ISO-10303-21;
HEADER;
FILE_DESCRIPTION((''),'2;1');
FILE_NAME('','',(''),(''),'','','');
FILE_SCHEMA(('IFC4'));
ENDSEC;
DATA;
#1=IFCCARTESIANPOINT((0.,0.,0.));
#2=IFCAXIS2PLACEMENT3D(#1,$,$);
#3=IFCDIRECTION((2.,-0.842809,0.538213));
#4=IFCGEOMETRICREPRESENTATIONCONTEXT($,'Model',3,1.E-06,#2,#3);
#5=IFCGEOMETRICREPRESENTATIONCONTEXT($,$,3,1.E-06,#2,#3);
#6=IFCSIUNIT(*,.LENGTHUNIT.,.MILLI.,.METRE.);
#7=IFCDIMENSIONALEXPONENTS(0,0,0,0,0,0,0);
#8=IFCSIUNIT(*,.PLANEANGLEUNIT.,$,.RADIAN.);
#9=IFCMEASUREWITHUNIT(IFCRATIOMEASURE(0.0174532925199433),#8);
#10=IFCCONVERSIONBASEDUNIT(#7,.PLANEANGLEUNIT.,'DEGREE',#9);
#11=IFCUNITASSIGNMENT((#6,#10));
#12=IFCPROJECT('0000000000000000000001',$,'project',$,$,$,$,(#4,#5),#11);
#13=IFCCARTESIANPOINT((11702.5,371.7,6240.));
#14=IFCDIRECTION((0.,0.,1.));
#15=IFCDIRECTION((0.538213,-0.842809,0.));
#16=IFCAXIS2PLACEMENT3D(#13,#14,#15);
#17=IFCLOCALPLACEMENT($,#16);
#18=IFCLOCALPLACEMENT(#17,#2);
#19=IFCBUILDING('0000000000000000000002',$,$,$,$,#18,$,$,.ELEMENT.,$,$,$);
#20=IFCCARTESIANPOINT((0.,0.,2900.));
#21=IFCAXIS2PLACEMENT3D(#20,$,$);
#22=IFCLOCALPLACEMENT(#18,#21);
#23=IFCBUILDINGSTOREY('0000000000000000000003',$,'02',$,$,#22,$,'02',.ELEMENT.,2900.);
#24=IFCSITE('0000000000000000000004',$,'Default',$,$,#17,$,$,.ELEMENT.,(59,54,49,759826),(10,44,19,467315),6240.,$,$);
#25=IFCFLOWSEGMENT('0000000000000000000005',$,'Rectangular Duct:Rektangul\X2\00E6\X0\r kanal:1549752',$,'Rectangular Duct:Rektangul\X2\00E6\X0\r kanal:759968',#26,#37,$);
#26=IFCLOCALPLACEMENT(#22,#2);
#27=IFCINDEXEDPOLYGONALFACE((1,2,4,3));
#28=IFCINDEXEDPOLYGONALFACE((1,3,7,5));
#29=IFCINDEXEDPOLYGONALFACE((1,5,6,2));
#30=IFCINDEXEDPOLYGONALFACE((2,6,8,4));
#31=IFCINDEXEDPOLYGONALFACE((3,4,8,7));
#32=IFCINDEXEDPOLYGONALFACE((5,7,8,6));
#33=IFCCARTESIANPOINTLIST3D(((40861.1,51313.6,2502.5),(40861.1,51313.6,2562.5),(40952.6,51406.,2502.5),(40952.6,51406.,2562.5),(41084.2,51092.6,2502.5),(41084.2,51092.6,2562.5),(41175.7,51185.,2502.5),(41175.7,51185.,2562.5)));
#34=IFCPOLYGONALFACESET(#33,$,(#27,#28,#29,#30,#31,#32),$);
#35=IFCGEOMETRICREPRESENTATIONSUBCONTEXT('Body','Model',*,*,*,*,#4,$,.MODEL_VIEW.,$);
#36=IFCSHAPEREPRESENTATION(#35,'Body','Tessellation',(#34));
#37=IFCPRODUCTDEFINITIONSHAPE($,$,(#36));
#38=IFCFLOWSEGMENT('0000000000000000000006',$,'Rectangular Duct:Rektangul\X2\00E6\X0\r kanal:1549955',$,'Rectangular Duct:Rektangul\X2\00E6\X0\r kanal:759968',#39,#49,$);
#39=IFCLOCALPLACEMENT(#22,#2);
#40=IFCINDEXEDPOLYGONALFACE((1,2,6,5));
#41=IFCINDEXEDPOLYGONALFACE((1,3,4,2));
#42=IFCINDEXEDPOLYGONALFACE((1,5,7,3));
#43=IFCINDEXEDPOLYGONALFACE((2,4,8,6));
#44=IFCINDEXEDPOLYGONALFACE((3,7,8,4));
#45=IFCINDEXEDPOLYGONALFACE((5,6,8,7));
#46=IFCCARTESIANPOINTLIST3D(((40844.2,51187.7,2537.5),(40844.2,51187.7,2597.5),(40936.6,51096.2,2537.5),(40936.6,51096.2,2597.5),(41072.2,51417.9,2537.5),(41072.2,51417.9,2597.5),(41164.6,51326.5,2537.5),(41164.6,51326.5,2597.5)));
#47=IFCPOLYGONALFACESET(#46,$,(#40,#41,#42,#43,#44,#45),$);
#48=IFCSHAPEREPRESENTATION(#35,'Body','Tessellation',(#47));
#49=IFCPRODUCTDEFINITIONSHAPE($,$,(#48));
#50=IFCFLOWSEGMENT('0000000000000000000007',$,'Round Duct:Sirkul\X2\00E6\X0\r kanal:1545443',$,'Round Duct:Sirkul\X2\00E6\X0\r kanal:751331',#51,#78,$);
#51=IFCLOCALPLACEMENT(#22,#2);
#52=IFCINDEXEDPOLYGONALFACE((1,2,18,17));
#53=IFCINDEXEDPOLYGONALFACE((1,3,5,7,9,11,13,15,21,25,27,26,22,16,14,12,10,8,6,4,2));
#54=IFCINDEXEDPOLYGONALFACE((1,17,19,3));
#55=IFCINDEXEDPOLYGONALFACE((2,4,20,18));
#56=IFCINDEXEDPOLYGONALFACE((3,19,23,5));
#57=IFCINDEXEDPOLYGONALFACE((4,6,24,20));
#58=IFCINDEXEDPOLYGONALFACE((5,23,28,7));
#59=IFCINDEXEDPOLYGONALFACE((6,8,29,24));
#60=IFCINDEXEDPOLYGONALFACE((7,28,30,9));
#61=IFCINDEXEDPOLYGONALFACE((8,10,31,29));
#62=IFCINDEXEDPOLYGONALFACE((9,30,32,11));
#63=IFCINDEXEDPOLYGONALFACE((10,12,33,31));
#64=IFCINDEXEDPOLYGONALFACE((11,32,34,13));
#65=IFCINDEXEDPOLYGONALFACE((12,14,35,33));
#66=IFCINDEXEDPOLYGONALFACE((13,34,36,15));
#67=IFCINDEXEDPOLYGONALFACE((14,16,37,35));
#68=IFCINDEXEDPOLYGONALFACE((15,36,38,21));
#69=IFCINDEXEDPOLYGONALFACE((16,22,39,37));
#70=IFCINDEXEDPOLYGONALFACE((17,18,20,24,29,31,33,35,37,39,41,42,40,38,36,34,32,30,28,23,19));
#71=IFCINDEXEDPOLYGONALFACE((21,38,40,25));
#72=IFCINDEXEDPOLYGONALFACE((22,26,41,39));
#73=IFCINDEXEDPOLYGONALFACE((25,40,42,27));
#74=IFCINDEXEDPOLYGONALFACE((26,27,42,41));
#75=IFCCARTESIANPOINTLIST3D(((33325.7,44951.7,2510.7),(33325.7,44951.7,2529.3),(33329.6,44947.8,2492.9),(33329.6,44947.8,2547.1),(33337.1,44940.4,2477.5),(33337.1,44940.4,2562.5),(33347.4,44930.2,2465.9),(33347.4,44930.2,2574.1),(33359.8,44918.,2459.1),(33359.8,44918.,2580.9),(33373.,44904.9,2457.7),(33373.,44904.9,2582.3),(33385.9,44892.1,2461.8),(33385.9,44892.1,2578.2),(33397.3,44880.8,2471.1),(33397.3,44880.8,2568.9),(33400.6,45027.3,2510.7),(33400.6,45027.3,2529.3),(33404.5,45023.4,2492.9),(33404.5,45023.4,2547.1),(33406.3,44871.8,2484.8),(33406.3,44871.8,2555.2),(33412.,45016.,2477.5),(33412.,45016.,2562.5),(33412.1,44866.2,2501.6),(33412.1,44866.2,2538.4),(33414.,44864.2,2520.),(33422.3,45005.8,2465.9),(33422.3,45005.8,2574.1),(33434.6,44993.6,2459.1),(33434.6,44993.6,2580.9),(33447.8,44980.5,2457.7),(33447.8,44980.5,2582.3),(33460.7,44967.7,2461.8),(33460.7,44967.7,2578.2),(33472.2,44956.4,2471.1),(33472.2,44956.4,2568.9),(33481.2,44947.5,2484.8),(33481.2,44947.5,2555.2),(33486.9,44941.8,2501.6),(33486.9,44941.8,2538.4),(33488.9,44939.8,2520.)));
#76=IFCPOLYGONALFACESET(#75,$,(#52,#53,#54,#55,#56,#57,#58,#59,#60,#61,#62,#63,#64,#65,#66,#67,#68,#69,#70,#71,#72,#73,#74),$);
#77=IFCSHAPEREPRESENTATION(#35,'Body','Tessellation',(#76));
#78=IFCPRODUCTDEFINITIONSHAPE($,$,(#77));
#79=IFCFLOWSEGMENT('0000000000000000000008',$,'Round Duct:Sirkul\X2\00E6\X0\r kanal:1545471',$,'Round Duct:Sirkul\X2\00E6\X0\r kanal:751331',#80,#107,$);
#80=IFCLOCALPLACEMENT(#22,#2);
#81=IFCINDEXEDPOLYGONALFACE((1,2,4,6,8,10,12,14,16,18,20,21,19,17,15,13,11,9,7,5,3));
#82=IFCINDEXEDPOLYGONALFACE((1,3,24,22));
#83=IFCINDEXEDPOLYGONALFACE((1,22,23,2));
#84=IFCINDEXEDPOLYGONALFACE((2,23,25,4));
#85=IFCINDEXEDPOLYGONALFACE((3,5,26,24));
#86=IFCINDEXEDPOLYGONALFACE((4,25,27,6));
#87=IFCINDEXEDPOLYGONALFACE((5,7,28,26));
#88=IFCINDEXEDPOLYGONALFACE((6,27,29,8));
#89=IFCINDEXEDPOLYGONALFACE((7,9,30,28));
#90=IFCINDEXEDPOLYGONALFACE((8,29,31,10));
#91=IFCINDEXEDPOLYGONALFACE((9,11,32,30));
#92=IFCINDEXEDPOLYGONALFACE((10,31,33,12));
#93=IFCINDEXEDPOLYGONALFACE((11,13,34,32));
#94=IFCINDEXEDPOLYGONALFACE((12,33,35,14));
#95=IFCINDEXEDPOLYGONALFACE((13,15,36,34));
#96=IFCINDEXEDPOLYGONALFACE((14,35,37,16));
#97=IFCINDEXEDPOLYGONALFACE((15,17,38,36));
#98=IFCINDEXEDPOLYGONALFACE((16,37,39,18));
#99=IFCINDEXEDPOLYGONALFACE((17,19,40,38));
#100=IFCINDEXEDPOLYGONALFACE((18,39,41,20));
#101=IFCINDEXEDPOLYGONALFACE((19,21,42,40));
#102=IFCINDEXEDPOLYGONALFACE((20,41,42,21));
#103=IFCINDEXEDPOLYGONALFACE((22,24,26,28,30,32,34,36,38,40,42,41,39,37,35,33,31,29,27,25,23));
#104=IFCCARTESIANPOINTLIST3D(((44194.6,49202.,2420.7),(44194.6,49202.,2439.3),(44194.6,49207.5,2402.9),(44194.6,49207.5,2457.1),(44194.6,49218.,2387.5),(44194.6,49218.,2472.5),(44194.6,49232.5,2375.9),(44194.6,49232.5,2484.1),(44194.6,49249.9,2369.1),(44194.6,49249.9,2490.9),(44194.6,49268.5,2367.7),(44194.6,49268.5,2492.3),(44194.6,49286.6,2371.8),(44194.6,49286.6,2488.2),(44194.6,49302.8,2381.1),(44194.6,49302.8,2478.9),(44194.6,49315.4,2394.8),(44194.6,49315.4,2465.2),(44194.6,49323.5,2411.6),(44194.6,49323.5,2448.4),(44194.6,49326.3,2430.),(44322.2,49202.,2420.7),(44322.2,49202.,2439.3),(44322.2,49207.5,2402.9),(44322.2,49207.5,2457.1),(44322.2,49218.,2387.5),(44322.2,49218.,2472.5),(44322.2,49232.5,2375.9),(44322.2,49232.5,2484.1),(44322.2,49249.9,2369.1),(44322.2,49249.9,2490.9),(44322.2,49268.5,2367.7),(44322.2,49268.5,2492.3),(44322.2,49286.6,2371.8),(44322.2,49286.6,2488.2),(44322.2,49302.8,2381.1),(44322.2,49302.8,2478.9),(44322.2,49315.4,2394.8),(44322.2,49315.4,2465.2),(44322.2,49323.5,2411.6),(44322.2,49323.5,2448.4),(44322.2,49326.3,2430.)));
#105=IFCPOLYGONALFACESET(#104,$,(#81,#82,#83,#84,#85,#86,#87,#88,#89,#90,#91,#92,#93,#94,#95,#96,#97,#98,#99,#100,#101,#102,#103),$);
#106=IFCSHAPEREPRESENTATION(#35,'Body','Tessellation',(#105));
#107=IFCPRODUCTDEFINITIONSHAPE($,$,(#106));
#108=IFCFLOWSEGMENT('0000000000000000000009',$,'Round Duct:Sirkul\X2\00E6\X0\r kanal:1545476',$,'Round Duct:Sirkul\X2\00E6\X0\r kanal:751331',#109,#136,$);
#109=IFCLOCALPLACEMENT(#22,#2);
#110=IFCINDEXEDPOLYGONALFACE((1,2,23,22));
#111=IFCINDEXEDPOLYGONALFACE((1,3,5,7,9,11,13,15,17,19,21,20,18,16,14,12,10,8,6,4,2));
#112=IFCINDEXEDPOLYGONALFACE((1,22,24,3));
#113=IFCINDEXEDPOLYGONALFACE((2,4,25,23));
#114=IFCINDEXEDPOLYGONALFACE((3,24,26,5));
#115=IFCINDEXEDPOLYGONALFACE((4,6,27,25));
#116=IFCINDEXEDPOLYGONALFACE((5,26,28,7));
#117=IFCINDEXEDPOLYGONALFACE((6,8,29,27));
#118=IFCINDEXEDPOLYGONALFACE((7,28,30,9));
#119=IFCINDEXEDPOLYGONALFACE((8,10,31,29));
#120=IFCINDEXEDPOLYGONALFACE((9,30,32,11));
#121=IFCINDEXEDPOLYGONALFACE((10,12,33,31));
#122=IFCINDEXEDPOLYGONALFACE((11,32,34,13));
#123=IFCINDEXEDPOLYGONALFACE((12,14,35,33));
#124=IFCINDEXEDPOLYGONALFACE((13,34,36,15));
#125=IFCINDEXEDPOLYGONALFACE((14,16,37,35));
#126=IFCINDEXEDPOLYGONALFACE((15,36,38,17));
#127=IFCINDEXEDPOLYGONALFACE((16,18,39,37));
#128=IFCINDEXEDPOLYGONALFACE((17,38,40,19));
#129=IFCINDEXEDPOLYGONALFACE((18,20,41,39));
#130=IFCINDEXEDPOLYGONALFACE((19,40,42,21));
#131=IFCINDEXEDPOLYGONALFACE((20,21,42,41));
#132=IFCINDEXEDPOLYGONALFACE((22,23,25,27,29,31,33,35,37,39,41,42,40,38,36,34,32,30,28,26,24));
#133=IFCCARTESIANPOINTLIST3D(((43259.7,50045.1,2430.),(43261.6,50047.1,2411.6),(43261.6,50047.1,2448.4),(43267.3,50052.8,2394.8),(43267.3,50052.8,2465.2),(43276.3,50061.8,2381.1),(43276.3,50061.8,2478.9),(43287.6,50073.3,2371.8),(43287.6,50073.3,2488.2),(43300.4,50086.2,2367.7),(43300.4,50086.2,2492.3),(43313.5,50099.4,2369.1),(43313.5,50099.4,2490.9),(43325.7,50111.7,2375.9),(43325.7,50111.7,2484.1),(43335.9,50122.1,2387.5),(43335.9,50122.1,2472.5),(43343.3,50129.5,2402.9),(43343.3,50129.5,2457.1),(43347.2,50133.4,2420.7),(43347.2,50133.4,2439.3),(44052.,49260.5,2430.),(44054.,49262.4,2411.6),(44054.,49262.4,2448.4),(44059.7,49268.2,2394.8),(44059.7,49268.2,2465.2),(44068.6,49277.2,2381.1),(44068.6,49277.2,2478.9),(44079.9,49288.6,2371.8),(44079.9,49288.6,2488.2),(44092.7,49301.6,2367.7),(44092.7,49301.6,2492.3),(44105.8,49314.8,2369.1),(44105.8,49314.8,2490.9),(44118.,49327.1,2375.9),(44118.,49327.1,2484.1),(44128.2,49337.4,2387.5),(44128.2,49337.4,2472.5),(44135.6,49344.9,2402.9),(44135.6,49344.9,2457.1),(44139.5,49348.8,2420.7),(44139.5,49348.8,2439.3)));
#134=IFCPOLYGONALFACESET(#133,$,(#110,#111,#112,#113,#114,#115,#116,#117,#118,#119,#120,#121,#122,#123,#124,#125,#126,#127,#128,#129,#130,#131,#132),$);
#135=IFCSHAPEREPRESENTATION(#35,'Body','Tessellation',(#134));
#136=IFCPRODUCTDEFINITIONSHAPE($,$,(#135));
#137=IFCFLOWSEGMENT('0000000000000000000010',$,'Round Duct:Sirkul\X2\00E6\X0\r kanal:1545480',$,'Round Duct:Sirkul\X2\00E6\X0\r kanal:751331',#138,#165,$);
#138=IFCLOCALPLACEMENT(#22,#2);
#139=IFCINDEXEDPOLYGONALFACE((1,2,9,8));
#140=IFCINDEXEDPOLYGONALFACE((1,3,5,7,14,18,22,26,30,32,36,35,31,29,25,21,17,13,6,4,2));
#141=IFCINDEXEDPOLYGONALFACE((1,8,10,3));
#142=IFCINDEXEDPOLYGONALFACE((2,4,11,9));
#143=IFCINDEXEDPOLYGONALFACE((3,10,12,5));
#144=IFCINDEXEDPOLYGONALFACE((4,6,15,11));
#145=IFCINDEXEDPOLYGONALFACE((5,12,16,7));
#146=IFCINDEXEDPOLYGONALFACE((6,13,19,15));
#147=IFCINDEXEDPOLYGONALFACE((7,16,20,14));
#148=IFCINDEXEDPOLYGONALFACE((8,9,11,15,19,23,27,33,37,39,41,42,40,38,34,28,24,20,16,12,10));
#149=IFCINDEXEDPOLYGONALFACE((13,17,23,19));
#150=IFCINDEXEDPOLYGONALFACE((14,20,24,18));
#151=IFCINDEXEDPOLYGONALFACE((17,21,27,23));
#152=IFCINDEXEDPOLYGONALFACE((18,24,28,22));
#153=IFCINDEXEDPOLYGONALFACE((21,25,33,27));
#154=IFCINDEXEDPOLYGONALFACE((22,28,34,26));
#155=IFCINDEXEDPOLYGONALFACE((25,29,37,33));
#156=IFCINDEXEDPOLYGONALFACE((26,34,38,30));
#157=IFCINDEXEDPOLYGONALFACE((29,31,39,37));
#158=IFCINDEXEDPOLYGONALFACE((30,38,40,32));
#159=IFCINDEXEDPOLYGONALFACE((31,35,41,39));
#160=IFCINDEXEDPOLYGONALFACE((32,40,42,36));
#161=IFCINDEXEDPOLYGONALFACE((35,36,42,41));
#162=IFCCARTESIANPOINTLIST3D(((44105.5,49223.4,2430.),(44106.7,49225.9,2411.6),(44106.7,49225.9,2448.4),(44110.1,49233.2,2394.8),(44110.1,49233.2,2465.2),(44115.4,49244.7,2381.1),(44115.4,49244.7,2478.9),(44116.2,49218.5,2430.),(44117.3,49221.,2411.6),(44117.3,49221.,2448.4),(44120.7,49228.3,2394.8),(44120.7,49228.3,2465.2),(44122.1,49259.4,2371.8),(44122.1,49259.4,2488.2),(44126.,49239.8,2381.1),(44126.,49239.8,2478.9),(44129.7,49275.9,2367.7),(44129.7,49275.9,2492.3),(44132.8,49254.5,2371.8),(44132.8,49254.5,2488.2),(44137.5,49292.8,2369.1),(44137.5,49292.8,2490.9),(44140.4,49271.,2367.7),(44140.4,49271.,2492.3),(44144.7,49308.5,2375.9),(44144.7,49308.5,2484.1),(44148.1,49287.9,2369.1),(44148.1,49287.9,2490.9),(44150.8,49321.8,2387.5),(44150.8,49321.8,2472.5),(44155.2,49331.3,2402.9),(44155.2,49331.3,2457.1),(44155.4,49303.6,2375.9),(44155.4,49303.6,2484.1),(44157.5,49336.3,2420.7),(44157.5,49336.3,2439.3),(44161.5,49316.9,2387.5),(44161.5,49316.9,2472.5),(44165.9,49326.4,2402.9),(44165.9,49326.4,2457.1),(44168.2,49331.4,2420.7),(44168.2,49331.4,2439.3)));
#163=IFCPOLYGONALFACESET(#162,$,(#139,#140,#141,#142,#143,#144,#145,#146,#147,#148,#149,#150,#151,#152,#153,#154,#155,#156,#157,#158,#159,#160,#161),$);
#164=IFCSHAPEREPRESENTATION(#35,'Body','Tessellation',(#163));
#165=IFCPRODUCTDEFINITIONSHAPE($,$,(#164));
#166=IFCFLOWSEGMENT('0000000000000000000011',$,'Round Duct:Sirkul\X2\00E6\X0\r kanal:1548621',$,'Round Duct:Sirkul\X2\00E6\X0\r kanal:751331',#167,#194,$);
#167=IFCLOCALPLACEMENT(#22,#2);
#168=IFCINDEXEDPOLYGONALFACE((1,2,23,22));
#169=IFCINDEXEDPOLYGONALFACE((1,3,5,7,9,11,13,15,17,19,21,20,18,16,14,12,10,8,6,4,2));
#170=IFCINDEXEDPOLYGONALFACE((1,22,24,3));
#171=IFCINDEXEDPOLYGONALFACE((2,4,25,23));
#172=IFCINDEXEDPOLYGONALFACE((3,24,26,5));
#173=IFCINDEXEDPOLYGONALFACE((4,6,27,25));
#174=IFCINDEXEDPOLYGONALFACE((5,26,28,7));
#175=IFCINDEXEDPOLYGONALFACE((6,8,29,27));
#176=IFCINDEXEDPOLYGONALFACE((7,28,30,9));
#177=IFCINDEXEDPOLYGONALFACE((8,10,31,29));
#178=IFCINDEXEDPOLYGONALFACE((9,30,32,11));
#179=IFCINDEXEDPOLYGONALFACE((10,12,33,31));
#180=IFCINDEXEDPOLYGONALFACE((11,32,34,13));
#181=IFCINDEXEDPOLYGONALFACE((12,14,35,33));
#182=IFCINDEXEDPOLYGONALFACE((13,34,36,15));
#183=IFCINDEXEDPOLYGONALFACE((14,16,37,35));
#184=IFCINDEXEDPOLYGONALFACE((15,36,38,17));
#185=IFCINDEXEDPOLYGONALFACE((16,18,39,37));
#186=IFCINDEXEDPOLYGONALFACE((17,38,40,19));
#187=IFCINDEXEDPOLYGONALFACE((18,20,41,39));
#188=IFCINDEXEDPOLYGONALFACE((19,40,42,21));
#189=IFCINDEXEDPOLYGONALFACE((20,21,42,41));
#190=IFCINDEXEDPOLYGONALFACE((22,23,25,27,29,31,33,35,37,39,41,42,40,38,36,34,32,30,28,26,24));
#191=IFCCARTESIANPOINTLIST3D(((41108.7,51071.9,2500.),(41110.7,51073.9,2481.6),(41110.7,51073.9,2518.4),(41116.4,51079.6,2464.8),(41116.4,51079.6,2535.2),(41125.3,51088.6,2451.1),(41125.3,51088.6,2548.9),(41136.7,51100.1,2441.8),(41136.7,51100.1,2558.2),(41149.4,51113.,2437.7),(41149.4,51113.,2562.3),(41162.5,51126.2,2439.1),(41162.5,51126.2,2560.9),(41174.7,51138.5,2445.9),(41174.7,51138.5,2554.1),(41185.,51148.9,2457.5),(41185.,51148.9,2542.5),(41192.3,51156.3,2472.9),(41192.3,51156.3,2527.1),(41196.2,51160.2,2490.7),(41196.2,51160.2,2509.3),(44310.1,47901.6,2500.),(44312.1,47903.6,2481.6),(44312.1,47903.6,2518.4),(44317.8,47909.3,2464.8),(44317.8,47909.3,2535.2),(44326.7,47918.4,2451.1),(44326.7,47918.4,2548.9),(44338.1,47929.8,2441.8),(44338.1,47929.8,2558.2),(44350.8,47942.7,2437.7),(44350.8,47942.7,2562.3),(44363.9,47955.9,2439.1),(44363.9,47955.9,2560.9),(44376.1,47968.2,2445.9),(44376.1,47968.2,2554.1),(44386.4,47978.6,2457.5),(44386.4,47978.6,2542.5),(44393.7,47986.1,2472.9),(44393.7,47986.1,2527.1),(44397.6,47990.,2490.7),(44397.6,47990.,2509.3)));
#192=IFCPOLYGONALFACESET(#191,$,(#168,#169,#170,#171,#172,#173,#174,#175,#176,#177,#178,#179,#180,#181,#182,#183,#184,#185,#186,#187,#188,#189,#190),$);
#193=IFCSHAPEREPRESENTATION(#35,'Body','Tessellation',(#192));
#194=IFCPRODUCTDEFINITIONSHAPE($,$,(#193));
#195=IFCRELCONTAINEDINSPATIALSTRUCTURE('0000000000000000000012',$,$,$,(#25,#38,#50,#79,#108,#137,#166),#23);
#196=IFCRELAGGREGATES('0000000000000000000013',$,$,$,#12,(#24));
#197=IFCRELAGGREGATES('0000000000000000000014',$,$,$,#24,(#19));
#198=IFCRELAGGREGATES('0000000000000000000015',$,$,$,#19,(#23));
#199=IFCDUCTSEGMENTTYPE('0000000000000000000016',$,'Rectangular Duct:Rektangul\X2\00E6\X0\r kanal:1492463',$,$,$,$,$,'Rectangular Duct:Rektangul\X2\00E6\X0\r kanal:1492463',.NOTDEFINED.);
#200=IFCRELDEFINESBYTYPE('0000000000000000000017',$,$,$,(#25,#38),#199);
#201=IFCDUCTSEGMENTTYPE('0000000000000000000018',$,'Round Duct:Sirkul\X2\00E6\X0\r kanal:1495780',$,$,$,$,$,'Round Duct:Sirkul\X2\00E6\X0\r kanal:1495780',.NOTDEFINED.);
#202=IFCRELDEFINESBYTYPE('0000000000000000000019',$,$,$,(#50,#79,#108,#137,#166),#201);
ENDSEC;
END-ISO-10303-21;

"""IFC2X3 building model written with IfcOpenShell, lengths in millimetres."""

from ifc_helpers import new_model, entity, si_unit, converted_unit, direction, frame, frame_2d, origin, origin_2d_with_axis, place, context, subcontext, project, spatial, rectangle, circle, extrude, type_object, element, save


model = new_model("IFC2X3")

# Units and contexts
model_context = context("Model", 3, precision=1e-06, world=origin(), true_north=direction((2.0, -0.842809, 0.538213)))
context_of_model = context(None, 3, precision=1e-06, world=origin(), true_north=direction((2.0, -0.842809, 0.538213)))
body_context = subcontext(model_context, "Body", "Model", "MODEL_VIEW")
ifc_project = project(units=[si_unit("LENGTHUNIT", "METRE", prefix="MILLI"), converted_unit("PLANEANGLEUNIT", "DEGREE", entity("IfcRatioMeasure", 0.0174532925199433), si_unit("PLANEANGLEUNIT", "RADIAN"), dimensions=[0, 0, 0, 0, 0, 0, 0])], contexts=[model_context, context_of_model])

# Site, building, storey
site_placement = place(None, frame((11702.5, 371.7, 6240.0), z_axis=(0.0, 0.0, 1.0), x_axis=(0.538213, -0.842809, 0.0)))
site = spatial("IfcSite", under=ifc_project, at=site_placement, Name="Default", CompositionType="ELEMENT", RefLatitude=(59, 54, 49, 759826), RefLongitude=(10, 44, 19, 467315), RefElevation=6240.0)
building_placement = place(site_placement, origin())
building = spatial("IfcBuilding", under=site, at=building_placement, CompositionType="ELEMENT")
storey_placement = place(building_placement, frame((0.0, 0.0, 2900.0)))
storey = spatial("IfcBuildingStorey", under=building, at=storey_placement, Name="02", LongName="02", CompositionType="ELEMENT", Elevation=2900.0)

# Flow segments
duct_segment_type_1 = type_object("IfcDuctSegmentType", Name="Rectangular Duct:Rektangulær kanal:1492463", ElementType="Rectangular Duct:Rektangulær kanal:1492463", PredefinedType="NOTDEFINED")
flow_segment_1_placement = place(storey_placement, origin())
element("IfcFlowSegment", 1, at=flow_segment_1_placement, inside=storey, type_object=duct_segment_type_1, Name="Rectangular Duct:Rektangulær kanal:1549752", ObjectType="Rectangular Duct:Rektangulær kanal:759968", context=body_context, shape_type="SweptSolid", body=[
    extrude(rectangle(XDim=314.0, YDim=130.0, at=frame_2d((0.0, 0.0), x_axis=(1.0, 0.0))), frame((41018.4, 51249.3, 2502.5), z_axis=(0.0, 0.0, 1.0), x_axis=(0.710554, -0.703643, 0.0)), (0.0, 0.0, 1.0), 60.0),
])
flow_segment_2_placement = place(storey_placement, origin())
element("IfcFlowSegment", 2, at=flow_segment_2_placement, inside=storey, type_object=duct_segment_type_1, Name="Rectangular Duct:Rektangulær kanal:1549955", ObjectType="Rectangular Duct:Rektangulær kanal:759968", context=body_context, shape_type="SweptSolid", body=[
    extrude(rectangle(XDim=324.0, YDim=130.0, at=origin_2d_with_axis()), frame((41004.4, 51257.1, 2537.5), z_axis=(0.0, 0.0, 1.0), x_axis=(0.703643, 0.710554, 0.0)), (0.0, 0.0, 1.0), 60.0),
])
duct_segment_type_2 = type_object("IfcDuctSegmentType", Name="Round Duct:Sirkulær kanal:1495780", ElementType="Round Duct:Sirkulær kanal:1495780", PredefinedType="NOTDEFINED")
flow_segment_3_placement = place(storey_placement, origin())
element("IfcFlowSegment", 3, at=flow_segment_3_placement, inside=storey, type_object=duct_segment_type_2, Name="Round Duct:Sirkulær kanal:1545443", ObjectType="Round Duct:Sirkulær kanal:751331", context=body_context, shape_type="SweptSolid", body=[
    extrude(circle(Radius=62.5, at=origin_2d_with_axis()), frame((33369.6, 44908.2, 2520.0), z_axis=(0.703643, 0.710554, 0.0), x_axis=(0.710554, -0.703643, 0.0)), (0.0, 0.0, 1.0), 106.4),
])
flow_segment_4_placement = place(storey_placement, origin())
element("IfcFlowSegment", 4, at=flow_segment_4_placement, inside=storey, type_object=duct_segment_type_2, Name="Round Duct:Sirkulær kanal:1545471", ObjectType="Round Duct:Sirkulær kanal:751331", context=body_context, shape_type="SweptSolid", body=[
    extrude(circle(Radius=62.5, at=origin_2d_with_axis()), frame((44194.6, 49263.8, 2430.0), z_axis=(1.0, 0.0, 0.0), x_axis=(0.0, 1.0, 0.0)), (0.0, 0.0, 1.0), 127.6),
])
flow_segment_5_placement = place(storey_placement, origin())
element("IfcFlowSegment", 5, at=flow_segment_5_placement, inside=storey, type_object=duct_segment_type_2, Name="Round Duct:Sirkulær kanal:1545476", ObjectType="Round Duct:Sirkulær kanal:751331", context=body_context, shape_type="SweptSolid", body=[
    extrude(circle(Radius=62.5, at=origin_2d_with_axis()), frame((43303.7, 50089.5, 2430.0), z_axis=(0.710534, -0.703663, 0.0), x_axis=(-0.703663, -0.710534, 0.0)), (0.0, 0.0, 1.0), 1115.1),
])
flow_segment_6_placement = place(storey_placement, origin())
element("IfcFlowSegment", 6, at=flow_segment_6_placement, inside=storey, type_object=duct_segment_type_2, Name="Round Duct:Sirkulær kanal:1545480", ObjectType="Round Duct:Sirkulær kanal:751331", context=body_context, shape_type="SweptSolid", body=[
    extrude(circle(Radius=62.5, at=frame_2d((0.0, 0.0), x_axis=(1.0, 0.0))), frame((44142.3, 49275.2, 2430.0), z_axis=(-0.908347, 0.418217, 0.0), x_axis=(-0.418217, -0.908347, 0.0)), (0.0, 0.0, 1.0), 11.7),
])
flow_segment_7_placement = place(storey_placement, origin())
element("IfcFlowSegment", 7, at=flow_segment_7_placement, inside=storey, type_object=duct_segment_type_2, Name="Round Duct:Sirkulær kanal:1548621", ObjectType="Round Duct:Sirkulær kanal:751331", context=body_context, shape_type="SweptSolid", body=[
    extrude(circle(Radius=62.5, at=origin_2d_with_axis()), frame((41152.7, 51116.3, 2500.0), z_axis=(0.710554, -0.703643, 0.0), x_axis=(-0.703643, -0.710554, 0.0)), (0.0, 0.0, 1.0), 4505.5),
])

save(model, "model.ifc")
